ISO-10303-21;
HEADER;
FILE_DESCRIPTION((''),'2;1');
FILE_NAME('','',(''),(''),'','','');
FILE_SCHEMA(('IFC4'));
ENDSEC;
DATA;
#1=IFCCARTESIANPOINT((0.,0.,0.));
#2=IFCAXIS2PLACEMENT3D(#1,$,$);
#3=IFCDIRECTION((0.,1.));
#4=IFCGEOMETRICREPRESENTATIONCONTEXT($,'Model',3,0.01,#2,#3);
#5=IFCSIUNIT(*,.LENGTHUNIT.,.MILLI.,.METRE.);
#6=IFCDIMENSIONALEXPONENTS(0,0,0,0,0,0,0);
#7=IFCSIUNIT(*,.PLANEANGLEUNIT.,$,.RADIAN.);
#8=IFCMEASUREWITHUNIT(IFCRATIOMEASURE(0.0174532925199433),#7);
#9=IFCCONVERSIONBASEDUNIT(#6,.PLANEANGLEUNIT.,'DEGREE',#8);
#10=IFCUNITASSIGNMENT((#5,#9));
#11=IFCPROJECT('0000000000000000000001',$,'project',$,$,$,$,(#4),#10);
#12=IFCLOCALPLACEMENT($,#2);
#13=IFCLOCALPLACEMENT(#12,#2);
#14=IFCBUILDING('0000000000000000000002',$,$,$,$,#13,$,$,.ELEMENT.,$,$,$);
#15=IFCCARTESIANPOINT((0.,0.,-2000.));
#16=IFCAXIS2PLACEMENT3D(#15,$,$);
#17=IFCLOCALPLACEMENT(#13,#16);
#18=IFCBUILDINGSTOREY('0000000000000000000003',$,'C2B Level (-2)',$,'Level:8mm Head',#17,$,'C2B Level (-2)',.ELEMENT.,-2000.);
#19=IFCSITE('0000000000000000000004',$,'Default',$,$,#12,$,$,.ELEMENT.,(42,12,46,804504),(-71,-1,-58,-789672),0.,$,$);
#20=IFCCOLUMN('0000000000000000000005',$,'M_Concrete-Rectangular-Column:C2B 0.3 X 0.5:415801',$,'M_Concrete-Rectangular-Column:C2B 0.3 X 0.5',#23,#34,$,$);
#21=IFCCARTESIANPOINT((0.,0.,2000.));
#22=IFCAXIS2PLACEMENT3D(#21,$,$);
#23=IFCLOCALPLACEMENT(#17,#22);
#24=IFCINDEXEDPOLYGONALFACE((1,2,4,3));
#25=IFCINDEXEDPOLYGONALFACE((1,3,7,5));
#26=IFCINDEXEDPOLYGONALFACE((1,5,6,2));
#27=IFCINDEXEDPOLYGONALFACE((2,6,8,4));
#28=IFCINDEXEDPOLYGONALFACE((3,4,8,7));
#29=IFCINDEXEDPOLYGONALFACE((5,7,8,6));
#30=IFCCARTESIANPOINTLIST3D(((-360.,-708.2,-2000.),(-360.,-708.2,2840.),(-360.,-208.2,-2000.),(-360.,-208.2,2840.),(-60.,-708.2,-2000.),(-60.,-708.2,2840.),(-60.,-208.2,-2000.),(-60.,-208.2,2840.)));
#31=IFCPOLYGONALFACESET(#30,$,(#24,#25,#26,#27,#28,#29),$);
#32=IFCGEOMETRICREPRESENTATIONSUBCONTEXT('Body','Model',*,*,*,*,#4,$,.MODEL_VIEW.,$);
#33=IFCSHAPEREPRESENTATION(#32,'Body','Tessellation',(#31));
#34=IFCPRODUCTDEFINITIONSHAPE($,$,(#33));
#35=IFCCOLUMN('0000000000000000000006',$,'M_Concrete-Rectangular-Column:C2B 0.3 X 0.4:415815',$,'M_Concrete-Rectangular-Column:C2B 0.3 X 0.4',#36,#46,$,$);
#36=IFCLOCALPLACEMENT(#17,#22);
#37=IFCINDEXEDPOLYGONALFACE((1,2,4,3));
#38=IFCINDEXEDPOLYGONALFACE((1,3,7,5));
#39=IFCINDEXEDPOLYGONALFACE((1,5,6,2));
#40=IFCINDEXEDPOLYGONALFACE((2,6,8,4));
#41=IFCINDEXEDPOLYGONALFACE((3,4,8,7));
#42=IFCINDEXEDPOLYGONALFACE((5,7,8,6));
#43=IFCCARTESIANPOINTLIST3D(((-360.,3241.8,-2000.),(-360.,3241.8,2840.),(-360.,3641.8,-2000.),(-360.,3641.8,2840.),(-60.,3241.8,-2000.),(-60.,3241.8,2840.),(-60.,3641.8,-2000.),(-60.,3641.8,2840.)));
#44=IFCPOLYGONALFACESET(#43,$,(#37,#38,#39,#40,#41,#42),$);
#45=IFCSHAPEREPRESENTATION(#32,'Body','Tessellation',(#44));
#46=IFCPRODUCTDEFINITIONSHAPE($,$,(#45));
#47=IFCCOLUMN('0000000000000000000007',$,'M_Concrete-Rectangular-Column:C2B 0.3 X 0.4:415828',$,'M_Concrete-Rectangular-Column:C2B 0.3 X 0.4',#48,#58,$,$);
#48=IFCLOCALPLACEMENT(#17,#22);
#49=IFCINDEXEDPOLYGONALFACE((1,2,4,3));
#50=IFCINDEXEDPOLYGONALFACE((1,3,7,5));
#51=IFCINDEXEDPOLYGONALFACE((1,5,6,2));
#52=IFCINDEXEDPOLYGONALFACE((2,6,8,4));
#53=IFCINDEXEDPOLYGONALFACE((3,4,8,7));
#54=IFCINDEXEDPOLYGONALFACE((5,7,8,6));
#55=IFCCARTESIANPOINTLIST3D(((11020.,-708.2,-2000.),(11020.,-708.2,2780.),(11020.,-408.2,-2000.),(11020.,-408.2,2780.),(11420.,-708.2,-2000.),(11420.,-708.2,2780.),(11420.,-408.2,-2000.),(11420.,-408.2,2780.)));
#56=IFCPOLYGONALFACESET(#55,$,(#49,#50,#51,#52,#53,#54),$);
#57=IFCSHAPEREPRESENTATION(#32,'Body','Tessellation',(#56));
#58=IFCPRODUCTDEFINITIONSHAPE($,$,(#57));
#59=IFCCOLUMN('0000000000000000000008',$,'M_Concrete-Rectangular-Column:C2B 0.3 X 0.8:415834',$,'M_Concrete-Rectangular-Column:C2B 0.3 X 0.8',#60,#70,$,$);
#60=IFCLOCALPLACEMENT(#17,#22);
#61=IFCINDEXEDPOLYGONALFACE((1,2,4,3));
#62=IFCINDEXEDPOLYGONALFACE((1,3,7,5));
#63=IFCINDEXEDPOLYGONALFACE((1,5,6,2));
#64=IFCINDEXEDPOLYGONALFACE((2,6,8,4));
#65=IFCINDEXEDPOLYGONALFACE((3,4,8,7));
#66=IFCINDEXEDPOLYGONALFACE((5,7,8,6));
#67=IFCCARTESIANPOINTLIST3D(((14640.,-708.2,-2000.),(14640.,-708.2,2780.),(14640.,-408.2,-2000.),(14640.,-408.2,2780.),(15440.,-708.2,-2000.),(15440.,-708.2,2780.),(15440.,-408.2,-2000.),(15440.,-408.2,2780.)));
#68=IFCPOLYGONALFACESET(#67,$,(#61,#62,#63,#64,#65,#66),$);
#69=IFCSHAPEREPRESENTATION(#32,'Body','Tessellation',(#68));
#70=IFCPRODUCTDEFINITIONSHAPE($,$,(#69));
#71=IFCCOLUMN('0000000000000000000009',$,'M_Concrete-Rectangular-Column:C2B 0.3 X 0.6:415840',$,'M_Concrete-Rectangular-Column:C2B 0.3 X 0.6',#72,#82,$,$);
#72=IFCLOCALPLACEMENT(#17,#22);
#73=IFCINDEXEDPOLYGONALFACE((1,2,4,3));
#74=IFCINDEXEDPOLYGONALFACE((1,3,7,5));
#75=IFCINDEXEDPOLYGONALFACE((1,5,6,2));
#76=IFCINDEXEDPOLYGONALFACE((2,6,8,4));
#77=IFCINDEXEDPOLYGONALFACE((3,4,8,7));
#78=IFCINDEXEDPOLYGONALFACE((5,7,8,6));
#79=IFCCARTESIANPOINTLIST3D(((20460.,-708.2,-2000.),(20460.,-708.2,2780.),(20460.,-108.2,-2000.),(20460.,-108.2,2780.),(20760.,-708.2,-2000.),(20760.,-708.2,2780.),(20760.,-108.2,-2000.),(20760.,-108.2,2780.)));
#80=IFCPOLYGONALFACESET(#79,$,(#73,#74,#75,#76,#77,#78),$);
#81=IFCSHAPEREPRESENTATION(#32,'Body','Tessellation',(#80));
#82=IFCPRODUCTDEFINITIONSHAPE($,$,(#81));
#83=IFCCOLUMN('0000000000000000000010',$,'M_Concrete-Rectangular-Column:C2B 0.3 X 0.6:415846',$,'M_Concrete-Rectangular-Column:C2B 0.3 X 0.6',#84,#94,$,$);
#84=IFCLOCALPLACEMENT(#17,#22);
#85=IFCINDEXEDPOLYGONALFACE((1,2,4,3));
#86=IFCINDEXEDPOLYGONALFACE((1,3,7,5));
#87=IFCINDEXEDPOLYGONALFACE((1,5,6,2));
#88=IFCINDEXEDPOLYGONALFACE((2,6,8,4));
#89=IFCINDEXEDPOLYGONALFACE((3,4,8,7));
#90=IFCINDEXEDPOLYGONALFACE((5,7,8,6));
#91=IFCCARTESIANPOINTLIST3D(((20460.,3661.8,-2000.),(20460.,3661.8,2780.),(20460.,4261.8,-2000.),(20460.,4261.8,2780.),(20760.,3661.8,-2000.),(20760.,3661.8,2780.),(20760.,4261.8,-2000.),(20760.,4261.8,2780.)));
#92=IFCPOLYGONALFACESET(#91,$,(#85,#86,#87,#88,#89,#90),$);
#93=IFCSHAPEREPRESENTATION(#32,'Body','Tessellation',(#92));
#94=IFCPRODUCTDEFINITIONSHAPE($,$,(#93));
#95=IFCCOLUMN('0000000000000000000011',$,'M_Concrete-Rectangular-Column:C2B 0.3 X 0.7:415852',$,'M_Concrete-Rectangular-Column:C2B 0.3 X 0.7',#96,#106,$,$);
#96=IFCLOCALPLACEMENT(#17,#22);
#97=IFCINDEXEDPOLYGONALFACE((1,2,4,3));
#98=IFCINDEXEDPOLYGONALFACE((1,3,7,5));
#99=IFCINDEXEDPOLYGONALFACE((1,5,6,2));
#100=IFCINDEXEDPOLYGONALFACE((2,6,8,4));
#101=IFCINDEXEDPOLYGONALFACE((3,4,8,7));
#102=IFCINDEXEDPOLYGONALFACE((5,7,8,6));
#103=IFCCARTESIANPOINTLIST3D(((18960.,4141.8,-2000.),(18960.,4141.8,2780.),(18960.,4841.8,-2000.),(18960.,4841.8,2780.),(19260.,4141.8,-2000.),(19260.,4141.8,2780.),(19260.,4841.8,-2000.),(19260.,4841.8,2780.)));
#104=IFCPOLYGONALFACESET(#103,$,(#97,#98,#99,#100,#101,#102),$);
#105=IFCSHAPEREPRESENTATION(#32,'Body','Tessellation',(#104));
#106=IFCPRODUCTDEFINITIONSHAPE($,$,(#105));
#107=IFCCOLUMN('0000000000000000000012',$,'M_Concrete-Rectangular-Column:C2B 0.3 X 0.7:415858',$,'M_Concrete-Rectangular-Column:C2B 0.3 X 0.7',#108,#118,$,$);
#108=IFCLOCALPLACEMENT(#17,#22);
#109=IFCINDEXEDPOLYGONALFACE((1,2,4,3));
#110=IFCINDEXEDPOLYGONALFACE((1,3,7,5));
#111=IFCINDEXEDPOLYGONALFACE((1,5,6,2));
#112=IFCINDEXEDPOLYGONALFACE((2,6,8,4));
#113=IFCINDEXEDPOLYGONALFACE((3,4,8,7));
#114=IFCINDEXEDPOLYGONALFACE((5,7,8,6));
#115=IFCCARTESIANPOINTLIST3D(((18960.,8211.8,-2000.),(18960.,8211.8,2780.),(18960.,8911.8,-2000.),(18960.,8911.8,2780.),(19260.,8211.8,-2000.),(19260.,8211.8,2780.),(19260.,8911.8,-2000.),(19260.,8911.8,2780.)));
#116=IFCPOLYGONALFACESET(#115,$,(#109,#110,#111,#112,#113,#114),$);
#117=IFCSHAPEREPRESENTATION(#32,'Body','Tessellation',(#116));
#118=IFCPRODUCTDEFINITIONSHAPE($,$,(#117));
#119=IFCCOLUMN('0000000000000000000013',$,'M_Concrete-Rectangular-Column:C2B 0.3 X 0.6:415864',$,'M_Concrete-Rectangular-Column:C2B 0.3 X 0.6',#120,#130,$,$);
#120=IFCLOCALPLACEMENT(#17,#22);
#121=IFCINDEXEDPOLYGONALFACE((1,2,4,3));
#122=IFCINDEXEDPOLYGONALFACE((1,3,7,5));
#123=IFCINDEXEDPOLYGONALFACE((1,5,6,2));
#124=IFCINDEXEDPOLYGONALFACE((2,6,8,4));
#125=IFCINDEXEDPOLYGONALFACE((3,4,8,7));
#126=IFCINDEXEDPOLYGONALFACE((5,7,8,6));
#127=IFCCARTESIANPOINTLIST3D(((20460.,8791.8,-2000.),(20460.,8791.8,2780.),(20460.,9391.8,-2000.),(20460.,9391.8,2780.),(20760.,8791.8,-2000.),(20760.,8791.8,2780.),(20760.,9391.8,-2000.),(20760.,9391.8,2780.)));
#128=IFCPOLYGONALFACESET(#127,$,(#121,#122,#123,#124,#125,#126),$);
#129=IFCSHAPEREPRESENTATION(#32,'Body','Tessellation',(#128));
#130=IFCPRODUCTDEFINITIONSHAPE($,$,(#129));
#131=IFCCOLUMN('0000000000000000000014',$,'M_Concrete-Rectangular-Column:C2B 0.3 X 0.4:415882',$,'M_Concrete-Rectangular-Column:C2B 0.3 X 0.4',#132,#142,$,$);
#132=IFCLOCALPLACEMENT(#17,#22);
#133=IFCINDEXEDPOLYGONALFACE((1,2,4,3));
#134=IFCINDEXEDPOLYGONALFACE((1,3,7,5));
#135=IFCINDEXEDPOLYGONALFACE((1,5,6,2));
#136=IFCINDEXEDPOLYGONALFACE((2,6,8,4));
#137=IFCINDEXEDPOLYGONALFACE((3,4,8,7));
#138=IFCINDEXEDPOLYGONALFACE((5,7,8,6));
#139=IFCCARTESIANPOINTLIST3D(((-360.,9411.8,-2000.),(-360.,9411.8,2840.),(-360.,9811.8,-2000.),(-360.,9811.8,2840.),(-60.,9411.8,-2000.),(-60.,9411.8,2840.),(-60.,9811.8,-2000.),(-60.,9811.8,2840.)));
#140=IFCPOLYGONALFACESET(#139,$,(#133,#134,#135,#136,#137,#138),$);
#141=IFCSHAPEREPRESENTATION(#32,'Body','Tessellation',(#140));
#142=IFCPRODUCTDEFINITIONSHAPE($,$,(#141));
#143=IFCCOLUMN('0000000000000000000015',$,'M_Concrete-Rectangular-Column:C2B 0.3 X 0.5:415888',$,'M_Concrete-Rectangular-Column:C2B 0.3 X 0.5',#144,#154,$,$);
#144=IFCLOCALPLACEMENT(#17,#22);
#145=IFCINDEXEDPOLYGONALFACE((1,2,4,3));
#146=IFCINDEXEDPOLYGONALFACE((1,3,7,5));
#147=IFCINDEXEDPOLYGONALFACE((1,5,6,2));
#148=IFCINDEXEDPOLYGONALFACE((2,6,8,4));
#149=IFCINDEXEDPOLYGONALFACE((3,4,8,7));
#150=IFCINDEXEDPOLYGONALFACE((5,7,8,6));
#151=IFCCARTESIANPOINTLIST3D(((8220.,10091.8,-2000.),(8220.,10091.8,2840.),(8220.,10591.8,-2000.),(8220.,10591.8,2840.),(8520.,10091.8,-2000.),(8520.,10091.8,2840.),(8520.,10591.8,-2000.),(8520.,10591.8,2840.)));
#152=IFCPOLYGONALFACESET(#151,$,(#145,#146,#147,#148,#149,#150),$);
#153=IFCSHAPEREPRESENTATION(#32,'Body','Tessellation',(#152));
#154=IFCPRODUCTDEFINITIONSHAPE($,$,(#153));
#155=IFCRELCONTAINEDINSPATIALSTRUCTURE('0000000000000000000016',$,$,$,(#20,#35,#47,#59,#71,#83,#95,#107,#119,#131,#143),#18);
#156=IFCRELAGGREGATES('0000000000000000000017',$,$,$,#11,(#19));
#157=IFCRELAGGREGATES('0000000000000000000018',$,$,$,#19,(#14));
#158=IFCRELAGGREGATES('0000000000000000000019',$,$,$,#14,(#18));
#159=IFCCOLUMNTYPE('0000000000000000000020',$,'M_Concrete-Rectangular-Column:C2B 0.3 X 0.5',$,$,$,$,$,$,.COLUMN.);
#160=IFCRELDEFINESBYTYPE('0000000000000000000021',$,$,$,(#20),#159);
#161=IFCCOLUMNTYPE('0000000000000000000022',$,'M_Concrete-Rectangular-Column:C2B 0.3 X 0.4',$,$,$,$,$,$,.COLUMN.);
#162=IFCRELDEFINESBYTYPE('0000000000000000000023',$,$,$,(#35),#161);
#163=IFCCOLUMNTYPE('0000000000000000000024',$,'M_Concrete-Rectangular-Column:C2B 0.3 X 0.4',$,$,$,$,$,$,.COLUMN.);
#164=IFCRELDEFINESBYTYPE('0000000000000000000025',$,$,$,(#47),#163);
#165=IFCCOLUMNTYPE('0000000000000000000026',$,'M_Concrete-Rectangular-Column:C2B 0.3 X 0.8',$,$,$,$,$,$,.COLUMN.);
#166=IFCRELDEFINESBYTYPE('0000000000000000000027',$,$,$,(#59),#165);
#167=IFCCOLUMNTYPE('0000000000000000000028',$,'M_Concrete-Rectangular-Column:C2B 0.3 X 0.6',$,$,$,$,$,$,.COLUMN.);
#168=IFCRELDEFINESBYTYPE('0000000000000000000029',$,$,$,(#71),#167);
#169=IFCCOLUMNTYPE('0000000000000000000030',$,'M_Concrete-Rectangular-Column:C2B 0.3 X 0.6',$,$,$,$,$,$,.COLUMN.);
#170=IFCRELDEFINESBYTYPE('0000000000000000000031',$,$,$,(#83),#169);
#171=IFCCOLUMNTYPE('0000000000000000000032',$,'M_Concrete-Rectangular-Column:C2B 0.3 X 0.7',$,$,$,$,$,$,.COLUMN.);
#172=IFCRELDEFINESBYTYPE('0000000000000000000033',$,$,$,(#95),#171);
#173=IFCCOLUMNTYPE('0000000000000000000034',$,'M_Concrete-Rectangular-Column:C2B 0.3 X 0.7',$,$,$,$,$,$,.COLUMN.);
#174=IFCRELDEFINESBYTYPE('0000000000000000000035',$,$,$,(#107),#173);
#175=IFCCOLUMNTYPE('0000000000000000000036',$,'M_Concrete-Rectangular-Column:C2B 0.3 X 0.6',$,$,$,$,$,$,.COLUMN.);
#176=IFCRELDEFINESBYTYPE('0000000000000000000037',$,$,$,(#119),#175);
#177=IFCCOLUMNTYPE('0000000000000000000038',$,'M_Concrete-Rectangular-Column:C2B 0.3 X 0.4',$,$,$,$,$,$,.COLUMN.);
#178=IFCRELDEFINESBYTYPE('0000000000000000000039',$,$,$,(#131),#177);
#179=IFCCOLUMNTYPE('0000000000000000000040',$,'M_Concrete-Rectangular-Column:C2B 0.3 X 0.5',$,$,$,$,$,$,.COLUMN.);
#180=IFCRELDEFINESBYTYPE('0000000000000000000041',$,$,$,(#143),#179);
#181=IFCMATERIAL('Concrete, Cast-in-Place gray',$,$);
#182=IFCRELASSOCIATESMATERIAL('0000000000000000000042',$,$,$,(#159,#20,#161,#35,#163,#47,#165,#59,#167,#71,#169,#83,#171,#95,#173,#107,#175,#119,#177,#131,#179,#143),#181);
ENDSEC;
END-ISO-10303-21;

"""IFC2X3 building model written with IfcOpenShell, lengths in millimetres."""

from ifc_helpers import new_model, entity, si_unit, converted_unit, direction, frame, frame_2d, origin, origin_2d_with_axis, place, context, subcontext, project, spatial, rectangle, extrude, source, transform, mapped, material, type_object, type_shapes, element, save


model = new_model("IFC2X3")

# Units and contexts
model_context = context("Model", 3, precision=0.01, world=origin(), true_north=direction((0.0, 1.0)))
body_context = subcontext(model_context, "Body", "Model", "MODEL_VIEW")
ifc_project = project(units=[si_unit("LENGTHUNIT", "METRE", prefix="MILLI"), converted_unit("PLANEANGLEUNIT", "DEGREE", entity("IfcRatioMeasure", 0.0174532925199433), si_unit("PLANEANGLEUNIT", "RADIAN"), dimensions=[0, 0, 0, 0, 0, 0, 0])], contexts=[model_context])

# Site, building, storey
site_placement = place(None, origin())
site = spatial("IfcSite", under=ifc_project, at=site_placement, Name="Default", CompositionType="ELEMENT", RefLatitude=(42, 12, 46, 804504), RefLongitude=(-71, -1, -58, -789672), RefElevation=0.0)
building_placement = place(site_placement, origin())
building = spatial("IfcBuilding", under=site, at=building_placement, CompositionType="ELEMENT")
storey_placement = place(building_placement, frame((0.0, 0.0, -2000.0)))
storey = spatial("IfcBuildingStorey", under=building, at=storey_placement, Name="C2B Level (-2)", ObjectType="Level:8mm Head", LongName="C2B Level (-2)", CompositionType="ELEMENT", Elevation=-2000.0)

# Columns
ifc_material = material(Name="Concrete, Cast-in-Place gray")
column_type_1 = type_object("IfcColumnType", Name="M_Concrete-Rectangular-Column:C2B 0.3 X 0.5", PredefinedType="COLUMN", material=ifc_material)
shared_shape_1 = source(origin(), body_context, "Body", "SweptSolid", [
    extrude(rectangle(XDim=500.0, YDim=300.0, at=frame_2d((0.0, 0.0), x_axis=(1.0, 0.0))), frame((-210.0, -458.2, -2000.0), z_axis=(0.0, 0.0, 1.0), x_axis=(0.0, -1.0, 0.0)), (0.0, 0.0, 1.0), 4840.0),
])
type_shapes(column_type_1, [shared_shape_1])
column_1_placement = place(storey_placement, frame((0.0, 0.0, 2000.0)))
element("IfcColumn", 1, at=column_1_placement, inside=storey, type_object=column_type_1, material=ifc_material, Name="M_Concrete-Rectangular-Column:C2B 0.3 X 0.5:415801", ObjectType="M_Concrete-Rectangular-Column:C2B 0.3 X 0.5", context=body_context, shape_type="MappedRepresentation", body=[
    mapped(shared_shape_1, transform((0.0, 0.0, 0.0), scale=1.0)),
])
column_type_2 = type_object("IfcColumnType", Name="M_Concrete-Rectangular-Column:C2B 0.3 X 0.4", PredefinedType="COLUMN", material=ifc_material)
shared_shape_2 = source(origin(), body_context, "Body", "SweptSolid", [
    extrude(rectangle(XDim=400.0, YDim=300.0, at=frame_2d((0.0, 0.0), x_axis=(1.0, 0.0))), frame((-210.0, 3441.8, -2000.0), z_axis=(0.0, 0.0, 1.0), x_axis=(0.0, -1.0, 0.0)), (0.0, 0.0, 1.0), 4840.0),
])
type_shapes(column_type_2, [shared_shape_2])
column_2_placement = place(storey_placement, frame((0.0, 0.0, 2000.0)))
element("IfcColumn", 2, at=column_2_placement, inside=storey, type_object=column_type_2, material=ifc_material, Name="M_Concrete-Rectangular-Column:C2B 0.3 X 0.4:415815", ObjectType="M_Concrete-Rectangular-Column:C2B 0.3 X 0.4", context=body_context, shape_type="MappedRepresentation", body=[
    mapped(shared_shape_2, transform((0.0, 0.0, 0.0), scale=1.0)),
])
column_type_3 = type_object("IfcColumnType", Name="M_Concrete-Rectangular-Column:C2B 0.3 X 0.4", PredefinedType="COLUMN", material=ifc_material)
shared_shape_3 = source(origin(), body_context, "Body", "SweptSolid", [
    extrude(rectangle(XDim=300.0, YDim=400.0, at=origin_2d_with_axis()), frame((11220.0, -558.2, -2000.0), z_axis=(0.0, 0.0, 1.0), x_axis=(0.0, -1.0, 0.0)), (0.0, 0.0, 1.0), 4780.0),
])
type_shapes(column_type_3, [shared_shape_3])
column_3_placement = place(storey_placement, frame((0.0, 0.0, 2000.0)))
element("IfcColumn", 3, at=column_3_placement, inside=storey, type_object=column_type_3, material=ifc_material, Name="M_Concrete-Rectangular-Column:C2B 0.3 X 0.4:415828", ObjectType="M_Concrete-Rectangular-Column:C2B 0.3 X 0.4", context=body_context, shape_type="MappedRepresentation", body=[
    mapped(shared_shape_3, transform((0.0, 0.0, 0.0), scale=1.0)),
])
column_type_4 = type_object("IfcColumnType", Name="M_Concrete-Rectangular-Column:C2B 0.3 X 0.8", PredefinedType="COLUMN", material=ifc_material)
shared_shape_4 = source(origin(), body_context, "Body", "SweptSolid", [
    extrude(rectangle(XDim=300.0, YDim=800.0, at=origin_2d_with_axis()), frame((15040.0, -558.2, -2000.0), z_axis=(0.0, 0.0, 1.0), x_axis=(0.0, -1.0, 0.0)), (0.0, 0.0, 1.0), 4780.0),
])
type_shapes(column_type_4, [shared_shape_4])
column_4_placement = place(storey_placement, frame((0.0, 0.0, 2000.0)))
element("IfcColumn", 4, at=column_4_placement, inside=storey, type_object=column_type_4, material=ifc_material, Name="M_Concrete-Rectangular-Column:C2B 0.3 X 0.8:415834", ObjectType="M_Concrete-Rectangular-Column:C2B 0.3 X 0.8", context=body_context, shape_type="MappedRepresentation", body=[
    mapped(shared_shape_4, transform((0.0, 0.0, 0.0), scale=1.0)),
])
column_type_5 = type_object("IfcColumnType", Name="M_Concrete-Rectangular-Column:C2B 0.3 X 0.6", PredefinedType="COLUMN", material=ifc_material)
shared_shape_5 = source(origin(), body_context, "Body", "SweptSolid", [
    extrude(rectangle(XDim=600.0, YDim=300.0, at=frame_2d((0.0, 0.0), x_axis=(1.0, 0.0))), frame((20610.0, -408.2, -2000.0), z_axis=(0.0, 0.0, 1.0), x_axis=(0.0, -1.0, 0.0)), (0.0, 0.0, 1.0), 4780.0),
])
type_shapes(column_type_5, [shared_shape_5])
column_5_placement = place(storey_placement, frame((0.0, 0.0, 2000.0)))
element("IfcColumn", 5, at=column_5_placement, inside=storey, type_object=column_type_5, material=ifc_material, Name="M_Concrete-Rectangular-Column:C2B 0.3 X 0.6:415840", ObjectType="M_Concrete-Rectangular-Column:C2B 0.3 X 0.6", context=body_context, shape_type="MappedRepresentation", body=[
    mapped(shared_shape_5, transform((0.0, 0.0, 0.0), scale=1.0)),
])
column_type_6 = type_object("IfcColumnType", Name="M_Concrete-Rectangular-Column:C2B 0.3 X 0.6", PredefinedType="COLUMN", material=ifc_material)
shared_shape_6 = source(origin(), body_context, "Body", "SweptSolid", [
    extrude(rectangle(XDim=600.0, YDim=300.0, at=origin_2d_with_axis()), frame((20610.0, 3961.8, -2000.0), z_axis=(0.0, 0.0, 1.0), x_axis=(0.0, -1.0, 0.0)), (0.0, 0.0, 1.0), 4780.0),
])
type_shapes(column_type_6, [shared_shape_6])
column_6_placement = place(storey_placement, frame((0.0, 0.0, 2000.0)))
element("IfcColumn", 6, at=column_6_placement, inside=storey, type_object=column_type_6, material=ifc_material, Name="M_Concrete-Rectangular-Column:C2B 0.3 X 0.6:415846", ObjectType="M_Concrete-Rectangular-Column:C2B 0.3 X 0.6", context=body_context, shape_type="MappedRepresentation", body=[
    mapped(shared_shape_6, transform((0.0, 0.0, 0.0), scale=1.0)),
])
column_type_7 = type_object("IfcColumnType", Name="M_Concrete-Rectangular-Column:C2B 0.3 X 0.7", PredefinedType="COLUMN", material=ifc_material)
shared_shape_7 = source(origin(), body_context, "Body", "SweptSolid", [
    extrude(rectangle(XDim=700.0, YDim=300.0, at=origin_2d_with_axis()), frame((19110.0, 4491.8, -2000.0), z_axis=(0.0, 0.0, 1.0), x_axis=(0.0, -1.0, 0.0)), (0.0, 0.0, 1.0), 4780.0),
])
type_shapes(column_type_7, [shared_shape_7])
column_7_placement = place(storey_placement, frame((0.0, 0.0, 2000.0)))
element("IfcColumn", 7, at=column_7_placement, inside=storey, type_object=column_type_7, material=ifc_material, Name="M_Concrete-Rectangular-Column:C2B 0.3 X 0.7:415852", ObjectType="M_Concrete-Rectangular-Column:C2B 0.3 X 0.7", context=body_context, shape_type="MappedRepresentation", body=[
    mapped(shared_shape_7, transform((0.0, 0.0, 0.0), scale=1.0)),
])
column_type_8 = type_object("IfcColumnType", Name="M_Concrete-Rectangular-Column:C2B 0.3 X 0.7", PredefinedType="COLUMN", material=ifc_material)
shared_shape_8 = source(origin(), body_context, "Body", "SweptSolid", [
    extrude(rectangle(XDim=700.0, YDim=300.0, at=origin_2d_with_axis()), frame((19110.0, 8561.8, -2000.0), z_axis=(0.0, 0.0, 1.0), x_axis=(0.0, -1.0, 0.0)), (0.0, 0.0, 1.0), 4780.0),
])
type_shapes(column_type_8, [shared_shape_8])
column_8_placement = place(storey_placement, frame((0.0, 0.0, 2000.0)))
element("IfcColumn", 8, at=column_8_placement, inside=storey, type_object=column_type_8, material=ifc_material, Name="M_Concrete-Rectangular-Column:C2B 0.3 X 0.7:415858", ObjectType="M_Concrete-Rectangular-Column:C2B 0.3 X 0.7", context=body_context, shape_type="MappedRepresentation", body=[
    mapped(shared_shape_8, transform((0.0, 0.0, 0.0), scale=1.0)),
])
column_type_9 = type_object("IfcColumnType", Name="M_Concrete-Rectangular-Column:C2B 0.3 X 0.6", PredefinedType="COLUMN", material=ifc_material)
shared_shape_9 = source(origin(), body_context, "Body", "SweptSolid", [
    extrude(rectangle(XDim=600.0, YDim=300.0, at=origin_2d_with_axis()), frame((20610.0, 9091.8, -2000.0), z_axis=(0.0, 0.0, 1.0), x_axis=(0.0, -1.0, 0.0)), (0.0, 0.0, 1.0), 4780.0),
])
type_shapes(column_type_9, [shared_shape_9])
column_9_placement = place(storey_placement, frame((0.0, 0.0, 2000.0)))
element("IfcColumn", 9, at=column_9_placement, inside=storey, type_object=column_type_9, material=ifc_material, Name="M_Concrete-Rectangular-Column:C2B 0.3 X 0.6:415864", ObjectType="M_Concrete-Rectangular-Column:C2B 0.3 X 0.6", context=body_context, shape_type="MappedRepresentation", body=[
    mapped(shared_shape_9, transform((0.0, 0.0, 0.0), scale=1.0)),
])
column_type_10 = type_object("IfcColumnType", Name="M_Concrete-Rectangular-Column:C2B 0.3 X 0.4", PredefinedType="COLUMN", material=ifc_material)
shared_shape_10 = source(origin(), body_context, "Body", "SweptSolid", [
    extrude(rectangle(XDim=400.0, YDim=300.0, at=frame_2d((0.0, 0.0), x_axis=(1.0, 0.0))), frame((-210.0, 9611.8, -2000.0), z_axis=(0.0, 0.0, 1.0), x_axis=(0.0, -1.0, 0.0)), (0.0, 0.0, 1.0), 4840.0),
])
type_shapes(column_type_10, [shared_shape_10])
column_10_placement = place(storey_placement, frame((0.0, 0.0, 2000.0)))
element("IfcColumn", 10, at=column_10_placement, inside=storey, type_object=column_type_10, material=ifc_material, Name="M_Concrete-Rectangular-Column:C2B 0.3 X 0.4:415882", ObjectType="M_Concrete-Rectangular-Column:C2B 0.3 X 0.4", context=body_context, shape_type="MappedRepresentation", body=[
    mapped(shared_shape_10, transform((0.0, 0.0, 0.0), scale=1.0)),
])
column_type_11 = type_object("IfcColumnType", Name="M_Concrete-Rectangular-Column:C2B 0.3 X 0.5", PredefinedType="COLUMN", material=ifc_material)
shared_shape_11 = source(origin(), body_context, "Body", "SweptSolid", [
    extrude(rectangle(XDim=500.0, YDim=300.0, at=frame_2d((0.0, 0.0), x_axis=(1.0, 0.0))), frame((8370.0, 10341.8, -2000.0), z_axis=(0.0, 0.0, 1.0), x_axis=(0.0, -1.0, 0.0)), (0.0, 0.0, 1.0), 4840.0),
])
type_shapes(column_type_11, [shared_shape_11])
column_11_placement = place(storey_placement, frame((0.0, 0.0, 2000.0)))
element("IfcColumn", 11, at=column_11_placement, inside=storey, type_object=column_type_11, material=ifc_material, Name="M_Concrete-Rectangular-Column:C2B 0.3 X 0.5:415888", ObjectType="M_Concrete-Rectangular-Column:C2B 0.3 X 0.5", context=body_context, shape_type="MappedRepresentation", body=[
    mapped(shared_shape_11, transform((0.0, 0.0, 0.0), scale=1.0)),
])

save(model, "model.ifc")
